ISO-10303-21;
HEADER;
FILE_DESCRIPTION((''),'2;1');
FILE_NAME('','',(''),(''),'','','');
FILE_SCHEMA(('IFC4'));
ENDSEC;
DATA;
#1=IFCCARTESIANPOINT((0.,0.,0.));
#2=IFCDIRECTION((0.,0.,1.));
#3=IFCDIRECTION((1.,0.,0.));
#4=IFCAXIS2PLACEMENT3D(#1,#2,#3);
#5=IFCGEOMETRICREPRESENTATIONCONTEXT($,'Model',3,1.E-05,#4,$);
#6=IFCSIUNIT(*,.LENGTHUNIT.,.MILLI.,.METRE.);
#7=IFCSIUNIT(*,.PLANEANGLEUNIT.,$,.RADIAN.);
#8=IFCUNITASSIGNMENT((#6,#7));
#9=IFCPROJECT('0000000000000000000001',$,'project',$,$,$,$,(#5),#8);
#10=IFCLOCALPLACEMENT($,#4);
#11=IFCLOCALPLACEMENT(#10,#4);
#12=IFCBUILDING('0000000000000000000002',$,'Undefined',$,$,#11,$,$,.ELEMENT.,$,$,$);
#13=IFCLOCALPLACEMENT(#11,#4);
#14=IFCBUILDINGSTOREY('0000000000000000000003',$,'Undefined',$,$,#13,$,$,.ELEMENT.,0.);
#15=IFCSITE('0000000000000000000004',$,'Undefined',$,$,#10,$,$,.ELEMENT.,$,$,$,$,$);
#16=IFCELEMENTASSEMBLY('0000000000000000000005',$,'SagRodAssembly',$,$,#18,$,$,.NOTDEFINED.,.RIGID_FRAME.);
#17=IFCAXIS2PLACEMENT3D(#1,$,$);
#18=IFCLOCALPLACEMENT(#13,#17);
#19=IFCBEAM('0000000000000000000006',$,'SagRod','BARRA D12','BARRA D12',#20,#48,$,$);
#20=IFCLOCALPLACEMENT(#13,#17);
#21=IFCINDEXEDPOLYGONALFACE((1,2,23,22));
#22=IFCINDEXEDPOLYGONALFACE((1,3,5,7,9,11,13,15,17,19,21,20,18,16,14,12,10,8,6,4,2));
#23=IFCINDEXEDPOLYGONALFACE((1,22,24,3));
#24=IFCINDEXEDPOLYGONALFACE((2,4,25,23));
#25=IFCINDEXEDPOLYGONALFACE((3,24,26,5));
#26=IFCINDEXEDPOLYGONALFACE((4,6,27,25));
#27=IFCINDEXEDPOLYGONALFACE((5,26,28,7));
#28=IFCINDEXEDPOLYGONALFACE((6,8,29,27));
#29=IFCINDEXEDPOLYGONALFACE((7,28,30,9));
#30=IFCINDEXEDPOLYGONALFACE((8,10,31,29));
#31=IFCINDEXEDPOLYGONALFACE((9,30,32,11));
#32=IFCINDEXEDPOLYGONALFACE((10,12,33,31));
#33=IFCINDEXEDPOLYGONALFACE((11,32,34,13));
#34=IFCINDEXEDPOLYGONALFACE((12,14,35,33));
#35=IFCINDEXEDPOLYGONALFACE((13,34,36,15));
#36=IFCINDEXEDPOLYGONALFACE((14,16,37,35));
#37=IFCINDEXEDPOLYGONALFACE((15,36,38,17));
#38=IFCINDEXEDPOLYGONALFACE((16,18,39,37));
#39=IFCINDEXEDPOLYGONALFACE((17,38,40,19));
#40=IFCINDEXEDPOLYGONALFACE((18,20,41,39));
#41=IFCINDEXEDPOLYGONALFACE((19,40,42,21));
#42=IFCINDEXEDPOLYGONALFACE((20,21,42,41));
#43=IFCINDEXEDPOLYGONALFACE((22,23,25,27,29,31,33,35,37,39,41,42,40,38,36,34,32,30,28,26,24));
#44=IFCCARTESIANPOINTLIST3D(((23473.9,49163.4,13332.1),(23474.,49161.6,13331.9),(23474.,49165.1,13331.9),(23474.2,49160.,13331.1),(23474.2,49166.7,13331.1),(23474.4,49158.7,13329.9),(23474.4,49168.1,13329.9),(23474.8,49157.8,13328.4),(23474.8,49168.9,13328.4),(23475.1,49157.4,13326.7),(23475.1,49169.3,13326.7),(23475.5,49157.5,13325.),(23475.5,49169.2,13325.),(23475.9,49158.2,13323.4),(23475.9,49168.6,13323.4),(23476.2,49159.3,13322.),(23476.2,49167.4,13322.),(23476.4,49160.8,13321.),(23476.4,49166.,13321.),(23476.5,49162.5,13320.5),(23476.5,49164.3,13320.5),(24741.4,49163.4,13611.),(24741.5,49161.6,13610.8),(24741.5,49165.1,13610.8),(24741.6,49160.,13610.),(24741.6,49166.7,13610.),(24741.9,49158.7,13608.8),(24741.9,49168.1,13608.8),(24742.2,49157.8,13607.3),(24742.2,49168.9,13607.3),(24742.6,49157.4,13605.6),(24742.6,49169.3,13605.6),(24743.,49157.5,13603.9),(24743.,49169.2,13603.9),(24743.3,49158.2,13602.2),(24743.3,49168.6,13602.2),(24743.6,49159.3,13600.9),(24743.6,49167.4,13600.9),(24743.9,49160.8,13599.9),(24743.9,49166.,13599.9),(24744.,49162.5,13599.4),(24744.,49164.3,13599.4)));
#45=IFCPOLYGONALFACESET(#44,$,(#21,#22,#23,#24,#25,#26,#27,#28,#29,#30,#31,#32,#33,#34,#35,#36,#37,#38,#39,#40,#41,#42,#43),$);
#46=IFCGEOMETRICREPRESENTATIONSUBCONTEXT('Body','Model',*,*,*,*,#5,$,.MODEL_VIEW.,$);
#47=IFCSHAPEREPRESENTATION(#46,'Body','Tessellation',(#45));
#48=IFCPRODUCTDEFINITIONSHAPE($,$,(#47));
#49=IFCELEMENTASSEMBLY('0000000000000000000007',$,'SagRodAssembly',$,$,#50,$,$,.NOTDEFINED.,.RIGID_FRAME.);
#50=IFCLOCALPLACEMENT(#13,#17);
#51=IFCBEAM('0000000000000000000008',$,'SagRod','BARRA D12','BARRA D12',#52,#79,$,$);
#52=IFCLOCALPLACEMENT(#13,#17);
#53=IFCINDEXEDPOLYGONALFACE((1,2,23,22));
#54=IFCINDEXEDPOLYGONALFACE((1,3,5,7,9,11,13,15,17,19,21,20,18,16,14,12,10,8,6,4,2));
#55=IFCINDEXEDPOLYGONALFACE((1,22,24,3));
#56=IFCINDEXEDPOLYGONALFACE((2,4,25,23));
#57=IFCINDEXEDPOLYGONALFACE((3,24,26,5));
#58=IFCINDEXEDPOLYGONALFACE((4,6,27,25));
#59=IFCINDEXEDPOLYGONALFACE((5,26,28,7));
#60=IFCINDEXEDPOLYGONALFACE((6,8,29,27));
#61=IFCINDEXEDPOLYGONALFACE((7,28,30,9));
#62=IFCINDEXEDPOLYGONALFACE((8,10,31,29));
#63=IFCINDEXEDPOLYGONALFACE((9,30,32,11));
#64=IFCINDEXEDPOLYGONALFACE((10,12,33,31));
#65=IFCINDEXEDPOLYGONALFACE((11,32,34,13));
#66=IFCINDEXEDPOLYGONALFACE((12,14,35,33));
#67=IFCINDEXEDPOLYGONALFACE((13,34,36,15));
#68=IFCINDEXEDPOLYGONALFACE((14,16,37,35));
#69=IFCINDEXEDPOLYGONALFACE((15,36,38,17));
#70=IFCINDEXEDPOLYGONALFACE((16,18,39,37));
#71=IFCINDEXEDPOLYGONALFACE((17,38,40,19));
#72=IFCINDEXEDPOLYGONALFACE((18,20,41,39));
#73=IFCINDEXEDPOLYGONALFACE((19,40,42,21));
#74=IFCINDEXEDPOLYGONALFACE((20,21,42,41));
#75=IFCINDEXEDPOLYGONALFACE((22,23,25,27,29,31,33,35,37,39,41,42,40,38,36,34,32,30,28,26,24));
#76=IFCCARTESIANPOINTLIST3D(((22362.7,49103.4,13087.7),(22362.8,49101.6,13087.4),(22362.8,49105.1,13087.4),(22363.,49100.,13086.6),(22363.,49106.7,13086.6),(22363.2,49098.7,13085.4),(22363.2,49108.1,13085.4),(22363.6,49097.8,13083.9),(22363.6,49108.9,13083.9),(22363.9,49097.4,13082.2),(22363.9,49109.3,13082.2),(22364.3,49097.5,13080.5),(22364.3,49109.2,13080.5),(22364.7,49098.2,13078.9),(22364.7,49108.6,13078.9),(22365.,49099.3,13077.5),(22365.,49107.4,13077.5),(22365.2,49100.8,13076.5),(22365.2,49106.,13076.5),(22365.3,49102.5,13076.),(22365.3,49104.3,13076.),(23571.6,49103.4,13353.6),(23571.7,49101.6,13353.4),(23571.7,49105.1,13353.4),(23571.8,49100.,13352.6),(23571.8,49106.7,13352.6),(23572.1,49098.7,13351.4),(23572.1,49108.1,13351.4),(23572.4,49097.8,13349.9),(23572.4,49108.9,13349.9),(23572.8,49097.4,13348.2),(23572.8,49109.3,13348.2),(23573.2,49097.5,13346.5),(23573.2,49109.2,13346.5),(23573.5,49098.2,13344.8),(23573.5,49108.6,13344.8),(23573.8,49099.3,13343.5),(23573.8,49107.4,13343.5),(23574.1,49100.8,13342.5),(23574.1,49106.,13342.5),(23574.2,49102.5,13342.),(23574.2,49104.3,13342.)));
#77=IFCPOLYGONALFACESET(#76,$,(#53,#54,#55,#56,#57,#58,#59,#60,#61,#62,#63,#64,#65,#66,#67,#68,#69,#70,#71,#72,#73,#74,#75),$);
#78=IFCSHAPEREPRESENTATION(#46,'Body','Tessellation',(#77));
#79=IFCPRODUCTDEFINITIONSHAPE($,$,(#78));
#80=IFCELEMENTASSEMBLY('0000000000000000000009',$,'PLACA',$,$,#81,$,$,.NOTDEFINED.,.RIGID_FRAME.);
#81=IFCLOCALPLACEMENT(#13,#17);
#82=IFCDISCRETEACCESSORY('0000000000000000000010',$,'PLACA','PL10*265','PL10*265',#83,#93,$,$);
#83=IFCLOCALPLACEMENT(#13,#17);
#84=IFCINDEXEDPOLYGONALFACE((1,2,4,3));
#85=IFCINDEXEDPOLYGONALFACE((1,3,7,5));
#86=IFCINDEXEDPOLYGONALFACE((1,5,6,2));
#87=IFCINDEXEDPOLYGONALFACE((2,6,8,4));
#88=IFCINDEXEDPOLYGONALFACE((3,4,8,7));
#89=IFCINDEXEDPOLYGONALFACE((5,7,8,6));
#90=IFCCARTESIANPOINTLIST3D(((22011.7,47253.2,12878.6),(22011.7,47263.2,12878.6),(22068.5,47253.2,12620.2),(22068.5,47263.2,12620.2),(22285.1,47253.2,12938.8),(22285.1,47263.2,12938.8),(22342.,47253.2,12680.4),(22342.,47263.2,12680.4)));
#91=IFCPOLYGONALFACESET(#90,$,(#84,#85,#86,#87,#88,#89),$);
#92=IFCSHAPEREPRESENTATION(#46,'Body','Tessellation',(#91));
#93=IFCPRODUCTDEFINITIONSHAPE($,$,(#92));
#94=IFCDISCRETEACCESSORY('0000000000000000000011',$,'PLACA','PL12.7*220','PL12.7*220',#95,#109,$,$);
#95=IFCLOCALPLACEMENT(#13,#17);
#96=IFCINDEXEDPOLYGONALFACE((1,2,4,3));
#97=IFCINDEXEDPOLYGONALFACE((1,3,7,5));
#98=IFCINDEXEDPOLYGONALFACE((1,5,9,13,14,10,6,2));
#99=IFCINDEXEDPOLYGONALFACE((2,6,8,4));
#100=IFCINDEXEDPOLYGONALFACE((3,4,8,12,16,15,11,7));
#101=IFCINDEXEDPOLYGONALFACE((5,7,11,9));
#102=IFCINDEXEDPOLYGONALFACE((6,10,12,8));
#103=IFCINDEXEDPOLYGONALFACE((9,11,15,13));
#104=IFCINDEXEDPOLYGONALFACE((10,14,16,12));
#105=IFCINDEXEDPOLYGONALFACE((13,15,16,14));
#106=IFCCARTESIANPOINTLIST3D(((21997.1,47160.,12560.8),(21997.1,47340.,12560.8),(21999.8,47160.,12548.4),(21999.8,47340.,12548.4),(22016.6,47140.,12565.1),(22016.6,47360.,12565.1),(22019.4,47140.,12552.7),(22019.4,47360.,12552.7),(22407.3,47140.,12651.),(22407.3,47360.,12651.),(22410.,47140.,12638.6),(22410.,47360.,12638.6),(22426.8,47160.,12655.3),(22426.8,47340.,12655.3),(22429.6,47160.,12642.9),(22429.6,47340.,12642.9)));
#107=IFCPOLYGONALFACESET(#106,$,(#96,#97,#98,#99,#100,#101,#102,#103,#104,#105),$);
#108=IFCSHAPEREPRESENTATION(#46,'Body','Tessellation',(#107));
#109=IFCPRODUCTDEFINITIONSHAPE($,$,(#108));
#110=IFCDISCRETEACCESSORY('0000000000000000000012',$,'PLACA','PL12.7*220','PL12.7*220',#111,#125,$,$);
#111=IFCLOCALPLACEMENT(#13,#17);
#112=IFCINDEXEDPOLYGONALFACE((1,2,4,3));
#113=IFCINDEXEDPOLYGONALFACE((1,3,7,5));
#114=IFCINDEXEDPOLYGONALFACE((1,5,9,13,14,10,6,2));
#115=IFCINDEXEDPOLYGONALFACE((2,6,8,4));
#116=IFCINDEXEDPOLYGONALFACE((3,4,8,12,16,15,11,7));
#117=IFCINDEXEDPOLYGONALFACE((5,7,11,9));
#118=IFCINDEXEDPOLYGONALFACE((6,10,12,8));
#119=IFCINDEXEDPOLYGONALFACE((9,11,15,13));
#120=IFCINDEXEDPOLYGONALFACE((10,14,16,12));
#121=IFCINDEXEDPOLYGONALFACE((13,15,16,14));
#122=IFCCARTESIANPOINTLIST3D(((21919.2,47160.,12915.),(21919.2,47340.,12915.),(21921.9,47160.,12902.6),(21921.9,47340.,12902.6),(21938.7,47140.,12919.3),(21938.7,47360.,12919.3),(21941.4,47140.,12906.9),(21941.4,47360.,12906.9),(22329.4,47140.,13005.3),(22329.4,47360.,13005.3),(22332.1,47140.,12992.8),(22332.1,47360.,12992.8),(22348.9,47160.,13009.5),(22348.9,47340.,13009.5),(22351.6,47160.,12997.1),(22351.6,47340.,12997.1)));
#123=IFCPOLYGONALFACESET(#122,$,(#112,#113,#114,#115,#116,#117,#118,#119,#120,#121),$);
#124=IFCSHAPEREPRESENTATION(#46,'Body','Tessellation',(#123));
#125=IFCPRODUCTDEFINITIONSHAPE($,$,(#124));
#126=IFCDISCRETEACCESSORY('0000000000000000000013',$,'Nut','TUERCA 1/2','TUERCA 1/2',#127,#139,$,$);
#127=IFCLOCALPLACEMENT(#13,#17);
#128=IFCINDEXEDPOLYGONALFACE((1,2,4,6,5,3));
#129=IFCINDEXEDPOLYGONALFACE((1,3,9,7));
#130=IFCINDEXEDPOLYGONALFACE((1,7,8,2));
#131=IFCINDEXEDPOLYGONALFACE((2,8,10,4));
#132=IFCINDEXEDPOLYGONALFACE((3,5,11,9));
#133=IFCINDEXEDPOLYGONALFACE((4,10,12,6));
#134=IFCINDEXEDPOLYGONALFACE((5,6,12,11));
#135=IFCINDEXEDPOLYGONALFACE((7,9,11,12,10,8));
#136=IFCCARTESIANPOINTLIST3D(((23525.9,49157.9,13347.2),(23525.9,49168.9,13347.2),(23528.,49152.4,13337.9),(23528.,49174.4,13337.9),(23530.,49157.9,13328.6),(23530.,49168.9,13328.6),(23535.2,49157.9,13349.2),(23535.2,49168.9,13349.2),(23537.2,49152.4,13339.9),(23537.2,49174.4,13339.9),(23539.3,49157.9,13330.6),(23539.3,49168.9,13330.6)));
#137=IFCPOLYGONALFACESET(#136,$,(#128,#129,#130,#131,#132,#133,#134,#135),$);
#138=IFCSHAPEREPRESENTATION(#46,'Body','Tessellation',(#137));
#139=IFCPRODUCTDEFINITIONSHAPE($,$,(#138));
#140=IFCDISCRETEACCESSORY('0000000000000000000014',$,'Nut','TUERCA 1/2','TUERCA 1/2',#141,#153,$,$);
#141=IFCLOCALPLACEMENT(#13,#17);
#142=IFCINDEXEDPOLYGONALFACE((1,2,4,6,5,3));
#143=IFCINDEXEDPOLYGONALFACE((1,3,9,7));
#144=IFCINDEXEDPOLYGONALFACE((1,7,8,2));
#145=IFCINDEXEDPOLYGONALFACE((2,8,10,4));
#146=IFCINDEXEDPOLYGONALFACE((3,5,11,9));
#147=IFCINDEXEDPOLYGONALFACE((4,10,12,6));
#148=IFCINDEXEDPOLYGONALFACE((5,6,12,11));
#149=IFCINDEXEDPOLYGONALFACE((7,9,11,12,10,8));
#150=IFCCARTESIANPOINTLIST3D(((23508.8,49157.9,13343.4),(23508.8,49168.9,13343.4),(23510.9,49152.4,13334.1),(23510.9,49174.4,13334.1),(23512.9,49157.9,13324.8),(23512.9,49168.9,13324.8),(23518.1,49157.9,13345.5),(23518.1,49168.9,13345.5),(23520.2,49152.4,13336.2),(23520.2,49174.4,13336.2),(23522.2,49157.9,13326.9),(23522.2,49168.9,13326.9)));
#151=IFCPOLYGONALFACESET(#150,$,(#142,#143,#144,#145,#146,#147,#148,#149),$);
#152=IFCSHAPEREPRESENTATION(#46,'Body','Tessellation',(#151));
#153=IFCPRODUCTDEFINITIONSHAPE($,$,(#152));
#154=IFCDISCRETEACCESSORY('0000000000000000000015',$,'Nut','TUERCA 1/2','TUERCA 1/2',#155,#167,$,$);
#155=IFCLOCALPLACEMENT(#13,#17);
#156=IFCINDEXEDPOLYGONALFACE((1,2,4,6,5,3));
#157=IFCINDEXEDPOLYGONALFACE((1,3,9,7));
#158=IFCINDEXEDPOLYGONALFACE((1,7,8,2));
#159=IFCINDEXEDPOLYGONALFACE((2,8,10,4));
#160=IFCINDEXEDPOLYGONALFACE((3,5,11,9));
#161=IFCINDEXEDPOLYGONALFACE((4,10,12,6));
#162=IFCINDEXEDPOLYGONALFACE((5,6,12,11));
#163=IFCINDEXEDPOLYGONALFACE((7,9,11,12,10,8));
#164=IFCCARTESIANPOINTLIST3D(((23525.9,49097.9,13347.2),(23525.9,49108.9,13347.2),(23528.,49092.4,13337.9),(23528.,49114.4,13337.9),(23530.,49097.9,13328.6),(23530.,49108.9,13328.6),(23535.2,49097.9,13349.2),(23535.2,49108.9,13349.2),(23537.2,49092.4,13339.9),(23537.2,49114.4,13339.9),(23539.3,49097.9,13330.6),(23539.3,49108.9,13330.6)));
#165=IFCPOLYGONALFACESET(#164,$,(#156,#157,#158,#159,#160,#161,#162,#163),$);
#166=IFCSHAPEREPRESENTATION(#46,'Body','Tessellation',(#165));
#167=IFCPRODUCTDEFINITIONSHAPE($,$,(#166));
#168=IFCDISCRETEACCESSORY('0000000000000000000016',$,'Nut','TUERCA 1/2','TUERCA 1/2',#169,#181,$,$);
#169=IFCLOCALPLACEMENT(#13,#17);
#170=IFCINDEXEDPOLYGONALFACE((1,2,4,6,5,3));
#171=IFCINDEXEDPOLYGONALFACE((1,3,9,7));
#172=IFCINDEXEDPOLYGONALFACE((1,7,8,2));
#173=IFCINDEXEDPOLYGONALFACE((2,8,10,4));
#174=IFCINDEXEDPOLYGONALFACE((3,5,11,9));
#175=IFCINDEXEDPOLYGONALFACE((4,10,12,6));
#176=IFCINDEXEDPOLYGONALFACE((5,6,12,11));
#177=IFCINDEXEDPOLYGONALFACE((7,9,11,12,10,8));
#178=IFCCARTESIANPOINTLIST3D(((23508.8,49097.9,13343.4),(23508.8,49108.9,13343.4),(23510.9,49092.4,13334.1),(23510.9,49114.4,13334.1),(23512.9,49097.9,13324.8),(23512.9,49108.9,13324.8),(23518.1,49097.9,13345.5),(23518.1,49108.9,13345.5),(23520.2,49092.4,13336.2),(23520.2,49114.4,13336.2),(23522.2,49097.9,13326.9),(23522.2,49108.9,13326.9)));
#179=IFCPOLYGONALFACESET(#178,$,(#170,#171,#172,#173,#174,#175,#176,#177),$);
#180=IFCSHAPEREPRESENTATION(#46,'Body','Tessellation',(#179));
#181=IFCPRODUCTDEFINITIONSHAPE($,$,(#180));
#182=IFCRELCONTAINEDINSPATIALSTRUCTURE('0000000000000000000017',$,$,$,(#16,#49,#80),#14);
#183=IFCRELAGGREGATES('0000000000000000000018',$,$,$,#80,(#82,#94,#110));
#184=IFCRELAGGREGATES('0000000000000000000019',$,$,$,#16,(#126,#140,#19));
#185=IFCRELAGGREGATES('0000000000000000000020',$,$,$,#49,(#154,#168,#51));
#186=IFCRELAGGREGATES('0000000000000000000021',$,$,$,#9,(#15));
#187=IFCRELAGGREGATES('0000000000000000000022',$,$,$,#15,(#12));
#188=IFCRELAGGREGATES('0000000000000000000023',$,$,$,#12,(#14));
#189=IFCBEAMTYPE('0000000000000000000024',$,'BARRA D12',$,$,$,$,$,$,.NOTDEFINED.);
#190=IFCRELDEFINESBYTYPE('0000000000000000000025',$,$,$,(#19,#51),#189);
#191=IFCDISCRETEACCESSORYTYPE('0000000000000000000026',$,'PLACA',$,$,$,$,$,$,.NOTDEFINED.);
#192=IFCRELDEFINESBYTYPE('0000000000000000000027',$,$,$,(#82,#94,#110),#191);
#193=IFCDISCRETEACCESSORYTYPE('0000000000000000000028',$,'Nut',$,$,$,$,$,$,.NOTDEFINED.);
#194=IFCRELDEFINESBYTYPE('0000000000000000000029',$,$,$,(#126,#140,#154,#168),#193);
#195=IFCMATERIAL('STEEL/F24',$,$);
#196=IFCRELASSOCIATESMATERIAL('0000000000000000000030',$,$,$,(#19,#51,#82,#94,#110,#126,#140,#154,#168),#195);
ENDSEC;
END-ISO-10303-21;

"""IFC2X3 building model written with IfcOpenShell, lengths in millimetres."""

from ifc_helpers import new_model, si_unit, frame, origin_with_axes, origin_2d_with_axis, place, context, subcontext, project, spatial, polyline, circle, outline, extrude, material, type_object, element, aggregate, save


model = new_model("IFC2X3")

# Units and contexts
model_context = context("Model", 3, precision=1e-05, world=origin_with_axes())
body_context = subcontext(model_context, "Body", "Model", "MODEL_VIEW")
ifc_project = project(units=[si_unit("LENGTHUNIT", "METRE", prefix="MILLI"), si_unit("PLANEANGLEUNIT", "RADIAN")], contexts=[model_context])

# Site, building, storey
site_placement = place(None, origin_with_axes())
site = spatial("IfcSite", under=ifc_project, at=site_placement, Name="Undefined", CompositionType="ELEMENT")
building_placement = place(site_placement, origin_with_axes())
building = spatial("IfcBuilding", under=site, at=building_placement, Name="Undefined", CompositionType="ELEMENT")
storey_placement = place(building_placement, origin_with_axes())
storey = spatial("IfcBuildingStorey", under=building, at=storey_placement, Name="Undefined", CompositionType="ELEMENT", Elevation=0.0)

# Element assemblies, beams
assembly_1_placement = place(storey_placement, origin_with_axes())
assembly_1 = element("IfcElementAssembly", 1, at=assembly_1_placement, inside=storey, Name="SagRodAssembly", AssemblyPlace="NOTDEFINED", PredefinedType="RIGID_FRAME")
ifc_material = material(Name="STEEL/F24")
beam_type = type_object("IfcBeamType", Name="BARRA D12", PredefinedType="NOTDEFINED")
beam_1_placement = place(assembly_1_placement, frame((23475.2, 49163.4, 13326.3), z_axis=(0.0, 1.0, 0.0), x_axis=(0.976639, 0.0, 0.214887)))
beam_1 = element("IfcBeam", 2, at=beam_1_placement, type_object=beam_type, material=ifc_material, Name="SagRod", Description="BARRA D12", ObjectType="BARRA D12", context=body_context, shape_type="SweptSolid", body=[
    extrude(circle(Radius=6.0, at=origin_2d_with_axis()), frame((1297.8, 0.0, 0.0), z_axis=(-1.0, 0.0, 0.0), x_axis=(0.0, -1.0, 0.0)), (0.0, 0.0, 1.0), 1297.8),
])
assembly_2_placement = place(storey_placement, origin_with_axes())
assembly_2 = element("IfcElementAssembly", 3, at=assembly_2_placement, inside=storey, Name="SagRodAssembly", AssemblyPlace="NOTDEFINED", PredefinedType="RIGID_FRAME")
beam_2_placement = place(assembly_2_placement, frame((22364.0, 49103.4, 13081.8), z_axis=(0.0, 1.0, 0.0), x_axis=(0.976639, 0.0, 0.214887)))
beam_2 = element("IfcBeam", 4, at=beam_2_placement, type_object=beam_type, material=ifc_material, Name="SagRod", Description="BARRA D12", ObjectType="BARRA D12", context=body_context, shape_type="SweptSolid", body=[
    extrude(circle(Radius=6.0, at=origin_2d_with_axis()), frame((1237.8, 0.0, 0.0), z_axis=(-1.0, 0.0, 0.0), x_axis=(0.0, -1.0, 0.0)), (0.0, 0.0, 1.0), 1237.8),
])

# Element assembly, discrete accessories
assembly_3_placement = place(storey_placement, origin_with_axes())
assembly_3 = element("IfcElementAssembly", 5, at=assembly_3_placement, inside=storey, Name="PLACA", AssemblyPlace="NOTDEFINED", PredefinedType="RIGID_FRAME")
discrete_accessory_type_1 = type_object("IfcDiscreteAccessoryType", Name="PLACA")
discrete_accessory_1_placement = place(assembly_3_placement, frame((22068.5, 47258.2, 12620.2), z_axis=(0.0, -1.0, 0.0), x_axis=(0.976639, 0.0, 0.214887)))
discrete_accessory_1 = element("IfcDiscreteAccessory", 6, at=discrete_accessory_1_placement, type_object=discrete_accessory_type_1, material=ifc_material, Name="PLACA", Description="PL10*265", ObjectType="PL10*265", context=body_context, shape_type="SweptSolid", body=[
    extrude(outline(polyline([(0.0, 0.0), (280.0, 0.0), (280.0, 264.6), (0.0, 264.6), (0.0, 0.0)])), frame((0.0, 0.0, -5.0), z_axis=(0.0, 0.0, 1.0), x_axis=(1.0, 0.0, 0.0)), (0.0, 0.0, 1.0), 10.0),
])
discrete_accessory_2_placement = place(assembly_3_placement, frame((21998.5, 47360.0, 12554.6), z_axis=(0.214887, 0.0, -0.976639), x_axis=(0.976639, 0.0, 0.214887)))
discrete_accessory_2 = element("IfcDiscreteAccessory", 7, at=discrete_accessory_2_placement, type_object=discrete_accessory_type_1, material=ifc_material, Name="PLACA", Description="PL12.7*220", ObjectType="PL12.7*220", context=body_context, shape_type="SweptSolid", body=[
    extrude(outline(polyline([(0.0, 20.0), (20.0, 0.0), (420.0, 0.0), (440.0, 20.0), (440.0, 200.0), (420.0, 220.0), (20.0, 220.0), (0.0, 200.0), (0.0, 20.0)])), frame((0.0, 0.0, -6.3), z_axis=(0.0, 0.0, 1.0), x_axis=(1.0, 0.0, 0.0)), (0.0, 0.0, 1.0), 12.7),
])
discrete_accessory_3_placement = place(assembly_3_placement, frame((21920.5, 47360.0, 12908.8), z_axis=(0.214887, 0.0, -0.976639), x_axis=(0.976639, 0.0, 0.214887)))
discrete_accessory_3 = element("IfcDiscreteAccessory", 8, at=discrete_accessory_3_placement, type_object=discrete_accessory_type_1, material=ifc_material, Name="PLACA", Description="PL12.7*220", ObjectType="PL12.7*220", context=body_context, shape_type="SweptSolid", body=[
    extrude(outline(polyline([(0.0, 20.0), (20.0, 0.0), (420.0, 0.0), (440.0, 20.0), (440.0, 200.0), (420.0, 220.0), (20.0, 220.0), (0.0, 200.0), (0.0, 20.0)])), frame((0.0, 0.0, -6.3), z_axis=(0.0, 0.0, 1.0), x_axis=(1.0, 0.0, 0.0)), (0.0, 0.0, 1.0), 12.7),
])
aggregate(assembly_3, [discrete_accessory_1, discrete_accessory_2, discrete_accessory_3])

# Discrete accessories
discrete_accessory_type_2 = type_object("IfcDiscreteAccessoryType", Name="Nut")
discrete_accessory_4_placement = place(assembly_1_placement, frame((23528.0, 49163.4, 13337.9), z_axis=(-0.214887, 0.0, 0.976639), x_axis=(0.976639, 0.0, 0.214887)))
discrete_accessory_4 = element("IfcDiscreteAccessory", 9, at=discrete_accessory_4_placement, type_object=discrete_accessory_type_2, material=ifc_material, Name="Nut", Description="TUERCA 1/2", ObjectType="TUERCA 1/2", context=body_context, shape_type="SweptSolid", body=[
    extrude(outline(polyline([(-5.5, 9.5), (5.5, 9.5), (11.0, 0.0), (5.5, -9.5), (-5.5, -9.5), (-11.0, 0.0), (-5.5, 9.5)])), frame((9.5, 0.0, 0.0), z_axis=(-1.0, 0.0, 0.0), x_axis=(0.0, -1.0, 0.0)), (0.0, 0.0, 1.0), 9.5),
])
discrete_accessory_5_placement = place(assembly_1_placement, frame((23510.9, 49163.4, 13334.1), z_axis=(-0.214887, 0.0, 0.976639), x_axis=(0.976639, 0.0, 0.214887)))
discrete_accessory_5 = element("IfcDiscreteAccessory", 10, at=discrete_accessory_5_placement, type_object=discrete_accessory_type_2, material=ifc_material, Name="Nut", Description="TUERCA 1/2", ObjectType="TUERCA 1/2", context=body_context, shape_type="SweptSolid", body=[
    extrude(outline(polyline([(-5.5, 9.5), (5.5, 9.5), (11.0, 0.0), (5.5, -9.5), (-5.5, -9.5), (-11.0, 0.0), (-5.5, 9.5)])), frame((9.5, 0.0, 0.0), z_axis=(-1.0, 0.0, 0.0), x_axis=(0.0, -1.0, 0.0)), (0.0, 0.0, 1.0), 9.5),
])
discrete_accessory_6_placement = place(assembly_2_placement, frame((23528.0, 49103.4, 13337.9), z_axis=(-0.214887, 0.0, 0.976639), x_axis=(0.976639, 0.0, 0.214887)))
discrete_accessory_6 = element("IfcDiscreteAccessory", 11, at=discrete_accessory_6_placement, type_object=discrete_accessory_type_2, material=ifc_material, Name="Nut", Description="TUERCA 1/2", ObjectType="TUERCA 1/2", context=body_context, shape_type="SweptSolid", body=[
    extrude(outline(polyline([(-5.5, 9.5), (5.5, 9.5), (11.0, 0.0), (5.5, -9.5), (-5.5, -9.5), (-11.0, 0.0), (-5.5, 9.5)])), frame((9.5, 0.0, 0.0), z_axis=(-1.0, 0.0, 0.0), x_axis=(0.0, -1.0, 0.0)), (0.0, 0.0, 1.0), 9.5),
])
discrete_accessory_7_placement = place(assembly_2_placement, frame((23510.9, 49103.4, 13334.1), z_axis=(-0.214887, 0.0, 0.976639), x_axis=(0.976639, 0.0, 0.214887)))
discrete_accessory_7 = element("IfcDiscreteAccessory", 12, at=discrete_accessory_7_placement, type_object=discrete_accessory_type_2, material=ifc_material, Name="Nut", Description="TUERCA 1/2", ObjectType="TUERCA 1/2", context=body_context, shape_type="SweptSolid", body=[
    extrude(outline(polyline([(-5.5, 9.5), (5.5, 9.5), (11.0, 0.0), (5.5, -9.5), (-5.5, -9.5), (-11.0, 0.0), (-5.5, 9.5)])), frame((9.5, 0.0, 0.0), z_axis=(-1.0, 0.0, 0.0), x_axis=(0.0, -1.0, 0.0)), (0.0, 0.0, 1.0), 9.5),
])

aggregate(assembly_1, [discrete_accessory_4, discrete_accessory_5, beam_1])
aggregate(assembly_2, [discrete_accessory_6, discrete_accessory_7, beam_2])

save(model, "model.ifc")
